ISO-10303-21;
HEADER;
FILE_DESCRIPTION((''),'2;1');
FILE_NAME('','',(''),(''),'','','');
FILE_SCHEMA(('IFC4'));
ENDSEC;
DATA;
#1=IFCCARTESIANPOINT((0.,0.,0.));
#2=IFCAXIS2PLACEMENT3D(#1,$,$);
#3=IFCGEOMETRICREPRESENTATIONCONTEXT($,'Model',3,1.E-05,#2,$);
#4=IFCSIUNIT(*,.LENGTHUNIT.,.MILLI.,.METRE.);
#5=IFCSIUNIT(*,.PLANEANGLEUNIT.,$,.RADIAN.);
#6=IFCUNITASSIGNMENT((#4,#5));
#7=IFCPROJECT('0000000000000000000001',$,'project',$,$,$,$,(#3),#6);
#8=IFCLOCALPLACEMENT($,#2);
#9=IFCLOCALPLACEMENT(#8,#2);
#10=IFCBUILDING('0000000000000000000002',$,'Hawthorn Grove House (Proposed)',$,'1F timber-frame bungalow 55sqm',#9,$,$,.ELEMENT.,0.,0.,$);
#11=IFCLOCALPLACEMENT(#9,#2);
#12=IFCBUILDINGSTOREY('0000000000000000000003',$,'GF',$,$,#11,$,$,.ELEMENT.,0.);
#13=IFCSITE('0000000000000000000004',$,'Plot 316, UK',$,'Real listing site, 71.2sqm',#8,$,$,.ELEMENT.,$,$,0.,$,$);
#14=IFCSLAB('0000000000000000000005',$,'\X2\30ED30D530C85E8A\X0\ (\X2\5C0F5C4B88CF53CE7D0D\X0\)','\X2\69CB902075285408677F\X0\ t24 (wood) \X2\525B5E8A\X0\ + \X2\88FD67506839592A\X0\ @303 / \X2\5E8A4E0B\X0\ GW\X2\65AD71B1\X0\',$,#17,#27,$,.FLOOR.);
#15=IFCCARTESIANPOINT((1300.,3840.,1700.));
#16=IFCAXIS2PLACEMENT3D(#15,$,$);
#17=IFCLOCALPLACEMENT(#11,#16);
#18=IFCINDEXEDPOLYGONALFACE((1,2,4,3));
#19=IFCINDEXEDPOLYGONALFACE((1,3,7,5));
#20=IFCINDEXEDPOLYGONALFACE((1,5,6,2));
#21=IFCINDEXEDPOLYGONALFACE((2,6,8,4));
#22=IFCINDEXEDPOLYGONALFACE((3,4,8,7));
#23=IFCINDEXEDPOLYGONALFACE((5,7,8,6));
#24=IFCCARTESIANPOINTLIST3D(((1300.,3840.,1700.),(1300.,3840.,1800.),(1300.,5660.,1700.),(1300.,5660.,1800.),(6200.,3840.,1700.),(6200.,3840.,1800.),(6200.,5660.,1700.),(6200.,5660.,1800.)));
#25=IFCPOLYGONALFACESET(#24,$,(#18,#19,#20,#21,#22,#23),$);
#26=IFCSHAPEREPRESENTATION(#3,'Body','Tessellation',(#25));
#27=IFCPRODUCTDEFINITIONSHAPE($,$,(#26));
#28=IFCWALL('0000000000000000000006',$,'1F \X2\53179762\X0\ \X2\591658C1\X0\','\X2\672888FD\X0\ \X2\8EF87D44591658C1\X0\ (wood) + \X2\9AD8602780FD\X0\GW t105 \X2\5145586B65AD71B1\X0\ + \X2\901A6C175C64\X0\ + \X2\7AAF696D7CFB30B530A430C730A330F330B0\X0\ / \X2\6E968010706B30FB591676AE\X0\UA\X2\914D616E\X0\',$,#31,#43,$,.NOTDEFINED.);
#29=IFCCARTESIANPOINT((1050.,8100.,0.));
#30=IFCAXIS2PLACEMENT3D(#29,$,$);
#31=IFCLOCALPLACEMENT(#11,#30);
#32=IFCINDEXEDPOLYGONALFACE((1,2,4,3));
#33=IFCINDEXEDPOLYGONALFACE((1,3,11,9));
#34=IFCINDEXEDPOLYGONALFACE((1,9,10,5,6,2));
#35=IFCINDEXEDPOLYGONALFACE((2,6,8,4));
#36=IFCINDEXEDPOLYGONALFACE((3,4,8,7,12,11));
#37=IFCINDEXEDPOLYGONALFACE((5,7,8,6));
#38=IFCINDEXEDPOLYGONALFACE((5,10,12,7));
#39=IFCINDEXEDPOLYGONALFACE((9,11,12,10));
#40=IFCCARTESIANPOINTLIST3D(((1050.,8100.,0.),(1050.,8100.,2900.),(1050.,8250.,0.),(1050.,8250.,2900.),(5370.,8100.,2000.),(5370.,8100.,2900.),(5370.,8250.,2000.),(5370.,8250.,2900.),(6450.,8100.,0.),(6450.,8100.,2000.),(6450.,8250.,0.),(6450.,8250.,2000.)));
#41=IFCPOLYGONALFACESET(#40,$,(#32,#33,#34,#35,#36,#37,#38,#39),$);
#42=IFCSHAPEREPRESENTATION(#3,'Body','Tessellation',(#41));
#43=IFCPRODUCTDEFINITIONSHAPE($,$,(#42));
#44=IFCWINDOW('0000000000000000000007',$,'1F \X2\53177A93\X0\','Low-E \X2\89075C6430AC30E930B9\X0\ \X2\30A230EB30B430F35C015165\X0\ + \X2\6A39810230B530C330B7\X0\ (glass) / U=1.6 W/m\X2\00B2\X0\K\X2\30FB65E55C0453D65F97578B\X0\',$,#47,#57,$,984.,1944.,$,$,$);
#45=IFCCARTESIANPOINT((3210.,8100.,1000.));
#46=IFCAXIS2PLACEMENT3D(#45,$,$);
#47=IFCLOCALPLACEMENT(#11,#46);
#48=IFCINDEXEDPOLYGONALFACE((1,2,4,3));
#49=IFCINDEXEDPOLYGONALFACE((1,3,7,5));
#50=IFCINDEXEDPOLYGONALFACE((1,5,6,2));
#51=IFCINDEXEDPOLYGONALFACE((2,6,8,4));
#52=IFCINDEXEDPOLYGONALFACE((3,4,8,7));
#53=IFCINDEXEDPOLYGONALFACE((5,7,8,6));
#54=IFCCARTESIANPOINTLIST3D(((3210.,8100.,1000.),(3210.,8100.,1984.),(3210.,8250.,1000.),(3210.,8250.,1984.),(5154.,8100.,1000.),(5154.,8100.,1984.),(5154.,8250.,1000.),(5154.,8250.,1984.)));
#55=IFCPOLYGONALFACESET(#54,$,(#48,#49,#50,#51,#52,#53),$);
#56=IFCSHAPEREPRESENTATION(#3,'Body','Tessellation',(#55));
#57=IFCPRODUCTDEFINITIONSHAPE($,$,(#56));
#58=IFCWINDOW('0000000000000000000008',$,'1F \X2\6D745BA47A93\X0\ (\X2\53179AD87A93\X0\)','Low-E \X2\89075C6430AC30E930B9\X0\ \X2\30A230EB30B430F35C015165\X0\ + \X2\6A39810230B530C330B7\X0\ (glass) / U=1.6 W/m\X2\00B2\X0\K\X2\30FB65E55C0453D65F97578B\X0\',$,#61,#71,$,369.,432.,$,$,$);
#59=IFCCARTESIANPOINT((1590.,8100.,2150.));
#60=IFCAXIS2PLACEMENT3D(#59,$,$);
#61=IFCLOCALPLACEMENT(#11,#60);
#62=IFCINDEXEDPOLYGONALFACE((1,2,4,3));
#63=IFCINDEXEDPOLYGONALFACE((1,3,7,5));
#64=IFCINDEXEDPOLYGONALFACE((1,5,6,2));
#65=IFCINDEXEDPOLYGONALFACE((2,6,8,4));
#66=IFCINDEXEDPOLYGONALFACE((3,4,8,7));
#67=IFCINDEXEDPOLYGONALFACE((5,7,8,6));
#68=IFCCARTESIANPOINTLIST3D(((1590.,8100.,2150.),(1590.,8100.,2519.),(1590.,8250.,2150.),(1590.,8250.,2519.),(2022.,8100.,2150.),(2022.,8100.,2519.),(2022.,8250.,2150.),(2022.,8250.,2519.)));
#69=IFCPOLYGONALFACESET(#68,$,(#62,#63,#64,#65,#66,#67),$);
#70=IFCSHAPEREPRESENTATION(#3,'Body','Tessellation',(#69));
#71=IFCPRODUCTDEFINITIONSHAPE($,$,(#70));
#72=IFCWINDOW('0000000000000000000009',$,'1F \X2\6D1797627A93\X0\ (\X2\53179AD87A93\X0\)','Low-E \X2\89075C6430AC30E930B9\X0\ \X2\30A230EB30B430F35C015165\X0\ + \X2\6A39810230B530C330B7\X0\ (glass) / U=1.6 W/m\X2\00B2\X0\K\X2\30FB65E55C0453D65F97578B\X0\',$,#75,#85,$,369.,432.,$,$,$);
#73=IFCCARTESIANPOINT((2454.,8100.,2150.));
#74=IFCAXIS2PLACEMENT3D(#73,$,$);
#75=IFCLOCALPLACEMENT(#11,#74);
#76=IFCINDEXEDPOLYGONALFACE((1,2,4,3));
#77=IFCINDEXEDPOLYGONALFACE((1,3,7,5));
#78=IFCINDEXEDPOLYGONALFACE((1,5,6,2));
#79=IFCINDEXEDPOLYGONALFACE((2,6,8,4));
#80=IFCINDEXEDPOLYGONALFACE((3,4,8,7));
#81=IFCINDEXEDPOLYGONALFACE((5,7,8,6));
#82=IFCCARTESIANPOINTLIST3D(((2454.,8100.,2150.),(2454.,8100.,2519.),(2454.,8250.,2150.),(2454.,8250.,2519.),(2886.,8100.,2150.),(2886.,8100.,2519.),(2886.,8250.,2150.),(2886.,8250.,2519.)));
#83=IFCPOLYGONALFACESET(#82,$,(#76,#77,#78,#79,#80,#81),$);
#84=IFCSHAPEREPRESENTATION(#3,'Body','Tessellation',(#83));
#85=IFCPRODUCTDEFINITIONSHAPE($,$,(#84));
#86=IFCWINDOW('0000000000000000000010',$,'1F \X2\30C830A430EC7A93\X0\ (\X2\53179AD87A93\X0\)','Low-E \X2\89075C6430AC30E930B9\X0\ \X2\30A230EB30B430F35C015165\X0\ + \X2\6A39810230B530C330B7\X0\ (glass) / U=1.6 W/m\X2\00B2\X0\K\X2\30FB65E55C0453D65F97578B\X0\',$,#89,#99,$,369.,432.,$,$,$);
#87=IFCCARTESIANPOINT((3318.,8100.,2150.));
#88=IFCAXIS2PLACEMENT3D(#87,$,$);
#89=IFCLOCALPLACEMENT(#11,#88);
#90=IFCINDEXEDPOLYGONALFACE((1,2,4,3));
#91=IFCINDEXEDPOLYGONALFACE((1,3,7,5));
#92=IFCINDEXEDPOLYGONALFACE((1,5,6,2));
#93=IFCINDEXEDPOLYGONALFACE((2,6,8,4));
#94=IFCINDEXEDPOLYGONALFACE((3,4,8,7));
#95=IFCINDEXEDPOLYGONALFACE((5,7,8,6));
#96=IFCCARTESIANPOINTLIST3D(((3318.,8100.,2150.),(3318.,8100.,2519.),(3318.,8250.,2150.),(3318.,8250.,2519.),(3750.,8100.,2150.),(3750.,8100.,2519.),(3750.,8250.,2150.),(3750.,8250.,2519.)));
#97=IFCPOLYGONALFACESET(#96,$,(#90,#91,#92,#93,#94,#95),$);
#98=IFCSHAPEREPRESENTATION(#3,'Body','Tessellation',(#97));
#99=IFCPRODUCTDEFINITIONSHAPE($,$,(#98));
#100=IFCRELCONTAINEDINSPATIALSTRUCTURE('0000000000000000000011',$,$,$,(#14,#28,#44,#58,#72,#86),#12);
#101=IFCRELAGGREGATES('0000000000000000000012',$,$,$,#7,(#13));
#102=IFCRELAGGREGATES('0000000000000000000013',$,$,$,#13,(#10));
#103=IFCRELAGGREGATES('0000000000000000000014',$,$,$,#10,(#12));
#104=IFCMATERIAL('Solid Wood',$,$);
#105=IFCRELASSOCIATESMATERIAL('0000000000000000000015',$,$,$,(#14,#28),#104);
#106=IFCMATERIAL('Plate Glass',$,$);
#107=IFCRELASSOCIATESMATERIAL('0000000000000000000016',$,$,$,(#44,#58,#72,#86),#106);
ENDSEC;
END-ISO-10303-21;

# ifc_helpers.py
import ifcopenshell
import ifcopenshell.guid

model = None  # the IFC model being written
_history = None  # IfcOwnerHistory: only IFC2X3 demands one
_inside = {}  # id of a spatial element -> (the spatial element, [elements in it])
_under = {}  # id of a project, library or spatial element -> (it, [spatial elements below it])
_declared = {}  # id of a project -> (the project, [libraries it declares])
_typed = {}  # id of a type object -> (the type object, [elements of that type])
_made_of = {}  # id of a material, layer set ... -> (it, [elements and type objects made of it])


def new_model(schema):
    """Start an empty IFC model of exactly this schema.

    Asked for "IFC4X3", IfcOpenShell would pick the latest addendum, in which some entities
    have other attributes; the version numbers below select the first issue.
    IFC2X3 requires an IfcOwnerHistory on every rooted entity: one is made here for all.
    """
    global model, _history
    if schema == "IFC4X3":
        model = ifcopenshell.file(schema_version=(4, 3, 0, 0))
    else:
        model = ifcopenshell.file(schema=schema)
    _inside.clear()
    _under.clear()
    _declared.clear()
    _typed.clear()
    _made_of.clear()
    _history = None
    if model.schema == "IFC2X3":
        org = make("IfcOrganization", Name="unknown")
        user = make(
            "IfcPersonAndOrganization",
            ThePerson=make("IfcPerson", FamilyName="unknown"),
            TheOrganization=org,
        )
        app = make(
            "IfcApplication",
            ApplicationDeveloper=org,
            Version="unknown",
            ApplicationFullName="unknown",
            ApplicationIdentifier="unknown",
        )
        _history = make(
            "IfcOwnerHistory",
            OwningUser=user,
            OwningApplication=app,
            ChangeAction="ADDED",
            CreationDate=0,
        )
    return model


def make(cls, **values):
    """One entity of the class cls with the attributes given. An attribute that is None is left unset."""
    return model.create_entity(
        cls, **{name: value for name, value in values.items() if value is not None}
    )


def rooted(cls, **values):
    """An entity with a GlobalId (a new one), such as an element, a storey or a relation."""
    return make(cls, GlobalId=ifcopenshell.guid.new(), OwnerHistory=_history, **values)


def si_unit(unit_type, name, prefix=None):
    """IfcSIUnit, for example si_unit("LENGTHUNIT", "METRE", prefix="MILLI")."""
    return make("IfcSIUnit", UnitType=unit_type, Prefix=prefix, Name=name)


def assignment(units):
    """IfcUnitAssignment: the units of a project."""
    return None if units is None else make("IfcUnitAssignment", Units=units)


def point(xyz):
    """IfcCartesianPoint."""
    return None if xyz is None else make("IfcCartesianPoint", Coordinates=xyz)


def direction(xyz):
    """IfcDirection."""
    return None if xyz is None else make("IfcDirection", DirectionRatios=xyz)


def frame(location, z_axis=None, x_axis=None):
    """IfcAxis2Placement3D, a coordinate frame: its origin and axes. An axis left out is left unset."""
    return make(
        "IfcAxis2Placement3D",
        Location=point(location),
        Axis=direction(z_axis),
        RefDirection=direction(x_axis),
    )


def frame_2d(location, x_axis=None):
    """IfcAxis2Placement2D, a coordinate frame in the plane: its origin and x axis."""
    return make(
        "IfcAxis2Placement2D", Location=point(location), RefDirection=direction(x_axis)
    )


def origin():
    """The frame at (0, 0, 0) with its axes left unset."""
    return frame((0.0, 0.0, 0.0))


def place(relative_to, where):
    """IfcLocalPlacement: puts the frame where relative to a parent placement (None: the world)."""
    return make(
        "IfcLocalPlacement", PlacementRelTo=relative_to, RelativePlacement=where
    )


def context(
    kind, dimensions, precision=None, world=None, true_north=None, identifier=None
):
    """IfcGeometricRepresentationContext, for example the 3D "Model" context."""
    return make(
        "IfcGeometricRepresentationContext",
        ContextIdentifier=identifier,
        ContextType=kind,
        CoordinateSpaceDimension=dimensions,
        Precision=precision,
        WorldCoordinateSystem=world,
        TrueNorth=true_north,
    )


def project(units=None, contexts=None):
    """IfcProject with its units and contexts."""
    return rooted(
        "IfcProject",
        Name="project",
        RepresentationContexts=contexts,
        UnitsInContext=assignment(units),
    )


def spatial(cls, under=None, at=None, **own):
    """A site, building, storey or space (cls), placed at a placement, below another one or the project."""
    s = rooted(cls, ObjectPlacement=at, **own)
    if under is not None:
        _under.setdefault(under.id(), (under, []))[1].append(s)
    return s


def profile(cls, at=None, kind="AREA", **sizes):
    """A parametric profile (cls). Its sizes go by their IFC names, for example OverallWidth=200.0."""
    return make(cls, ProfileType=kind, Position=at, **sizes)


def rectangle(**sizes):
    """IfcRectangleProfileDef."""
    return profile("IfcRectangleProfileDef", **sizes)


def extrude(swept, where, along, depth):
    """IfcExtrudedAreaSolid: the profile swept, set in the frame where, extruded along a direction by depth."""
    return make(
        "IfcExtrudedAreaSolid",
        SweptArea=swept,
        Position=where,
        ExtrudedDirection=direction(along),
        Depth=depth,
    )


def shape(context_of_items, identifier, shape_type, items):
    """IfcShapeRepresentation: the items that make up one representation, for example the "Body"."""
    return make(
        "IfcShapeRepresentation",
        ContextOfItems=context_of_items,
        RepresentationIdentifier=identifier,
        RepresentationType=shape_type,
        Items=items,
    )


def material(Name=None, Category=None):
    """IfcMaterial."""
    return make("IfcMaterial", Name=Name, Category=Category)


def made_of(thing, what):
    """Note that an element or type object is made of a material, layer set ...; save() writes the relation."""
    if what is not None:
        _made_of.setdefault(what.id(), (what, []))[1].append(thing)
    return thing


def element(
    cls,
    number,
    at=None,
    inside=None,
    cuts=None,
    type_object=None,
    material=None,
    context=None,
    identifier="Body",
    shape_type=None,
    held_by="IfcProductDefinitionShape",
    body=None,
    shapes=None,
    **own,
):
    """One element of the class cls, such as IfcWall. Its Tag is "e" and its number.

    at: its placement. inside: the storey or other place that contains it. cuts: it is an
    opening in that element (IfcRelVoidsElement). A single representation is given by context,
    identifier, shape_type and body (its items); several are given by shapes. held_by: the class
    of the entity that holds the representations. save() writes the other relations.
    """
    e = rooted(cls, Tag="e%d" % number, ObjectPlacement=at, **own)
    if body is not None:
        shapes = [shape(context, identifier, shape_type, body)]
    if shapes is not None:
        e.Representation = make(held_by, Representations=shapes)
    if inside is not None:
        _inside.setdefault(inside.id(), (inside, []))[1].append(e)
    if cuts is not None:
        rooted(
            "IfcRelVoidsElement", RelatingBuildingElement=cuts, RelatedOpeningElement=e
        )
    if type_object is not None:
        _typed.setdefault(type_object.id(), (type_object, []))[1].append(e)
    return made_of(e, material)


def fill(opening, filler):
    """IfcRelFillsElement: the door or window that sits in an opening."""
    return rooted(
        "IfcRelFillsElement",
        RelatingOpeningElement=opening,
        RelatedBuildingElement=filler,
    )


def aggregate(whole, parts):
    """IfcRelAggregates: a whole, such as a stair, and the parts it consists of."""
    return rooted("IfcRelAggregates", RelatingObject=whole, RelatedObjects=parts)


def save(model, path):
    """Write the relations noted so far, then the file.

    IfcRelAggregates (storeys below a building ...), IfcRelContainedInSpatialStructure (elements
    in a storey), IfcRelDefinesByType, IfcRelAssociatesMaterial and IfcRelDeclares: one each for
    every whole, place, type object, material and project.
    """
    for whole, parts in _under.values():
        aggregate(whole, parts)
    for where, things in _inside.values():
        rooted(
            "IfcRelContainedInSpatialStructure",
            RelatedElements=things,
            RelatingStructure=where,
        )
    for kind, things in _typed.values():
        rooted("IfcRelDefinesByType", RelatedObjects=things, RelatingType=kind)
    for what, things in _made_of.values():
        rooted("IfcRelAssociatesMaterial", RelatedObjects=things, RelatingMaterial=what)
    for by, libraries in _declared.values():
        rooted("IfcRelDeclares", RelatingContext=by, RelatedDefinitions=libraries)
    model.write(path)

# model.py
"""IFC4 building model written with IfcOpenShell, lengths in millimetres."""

from ifc_helpers import new_model, si_unit, frame, frame_2d, origin, place, context, project, spatial, rectangle, extrude, material, element, fill, save


model = new_model("IFC4")

# Units and contexts
model_context = context("Model", 3, precision=1e-05, world=origin())
ifc_project = project(units=[si_unit("LENGTHUNIT", "METRE", prefix="MILLI"), si_unit("PLANEANGLEUNIT", "RADIAN")], contexts=[model_context])

# Site, building, storey
site_placement = place(None, origin())
site = spatial("IfcSite", under=ifc_project, at=site_placement, Name="Plot 316, UK", ObjectType="Real listing site, 71.2sqm", CompositionType="ELEMENT", RefElevation=0.0)
building_placement = place(site_placement, origin())
building = spatial("IfcBuilding", under=site, at=building_placement, Name="Hawthorn Grove House (Proposed)", ObjectType="1F timber-frame bungalow 55sqm", CompositionType="ELEMENT", ElevationOfRefHeight=0.0, ElevationOfTerrain=0.0)
storey_placement = place(building_placement, origin())
storey = spatial("IfcBuildingStorey", under=building, at=storey_placement, Name="GF", CompositionType="ELEMENT", Elevation=0.0)

# Slab
ifc_material_1 = material(Name="Solid Wood")
slab_placement = place(storey_placement, frame((1300.0, 3840.0, 1700.0)))
element("IfcSlab", 1, at=slab_placement, inside=storey, material=ifc_material_1, Name="ロフト床 (小屋裏収納)", Description="構造用合板 t24 (wood) 剛床 + 製材根太 @303 / 床下 GW断熱", PredefinedType="FLOOR", context=model_context, shape_type="SweptSolid", body=[
    extrude(rectangle(XDim=4900.0, YDim=1820.0, at=frame_2d((2450.0, 910.0))), frame((1300.0, 3840.0, 1700.0)), (0.0, 0.0, 1.0), 100.0),
])

# Wall, openings, windows
wall_1_placement = place(storey_placement, frame((1050.0, 8100.0, 0.0)))
wall_1 = element("IfcWall", 2, at=wall_1_placement, inside=storey, material=ifc_material_1, Name="1F 北面 外壁", Description="木製 軸組外壁 (wood) + 高性能GW t105 充填断熱 + 通気層 + 窯業系サイディング / 準耐火・外皮UA配慮", PredefinedType="NOTDEFINED", context=model_context, shape_type="SweptSolid", body=[
    extrude(rectangle(XDim=5400.0, YDim=150.0, at=frame_2d((2700.0, 75.0))), frame((1050.0, 8100.0, 0.0)), (0.0, 0.0, 1.0), 2900.0),
])
opening_1_placement = place(storey_placement, frame((3210.0, 8100.0, 1000.0)))
opening_1 = element("IfcOpeningElement", 3, at=opening_1_placement, cuts=wall_1, PredefinedType="NOTDEFINED", context=model_context, shape_type="SweptSolid", body=[
    extrude(rectangle(XDim=1944.0, YDim=150.0, at=frame_2d((972.0, 75.0))), frame((3210.0, 8100.0, 1000.0)), (0.0, 0.0, 1.0), 984.0),
])
opening_2_placement = place(storey_placement, frame((1590.0, 8100.0, 2150.0)))
opening_2 = element("IfcOpeningElement", 4, at=opening_2_placement, cuts=wall_1, PredefinedType="NOTDEFINED", context=model_context, shape_type="SweptSolid", body=[
    extrude(rectangle(XDim=432.0, YDim=150.0, at=frame_2d((216.0, 75.0))), frame((1590.0, 8100.0, 2150.0)), (0.0, 0.0, 1.0), 369.0),
])
opening_3_placement = place(storey_placement, frame((2454.0, 8100.0, 2150.0)))
opening_3 = element("IfcOpeningElement", 5, at=opening_3_placement, cuts=wall_1, PredefinedType="NOTDEFINED", context=model_context, shape_type="SweptSolid", body=[
    extrude(rectangle(XDim=432.0, YDim=150.0, at=frame_2d((216.0, 75.0))), frame((2454.0, 8100.0, 2150.0)), (0.0, 0.0, 1.0), 369.0),
])
opening_4_placement = place(storey_placement, frame((3318.0, 8100.0, 2150.0)))
opening_4 = element("IfcOpeningElement", 6, at=opening_4_placement, cuts=wall_1, PredefinedType="NOTDEFINED", context=model_context, shape_type="SweptSolid", body=[
    extrude(rectangle(XDim=432.0, YDim=150.0, at=frame_2d((216.0, 75.0))), frame((3318.0, 8100.0, 2150.0)), (0.0, 0.0, 1.0), 369.0),
])
ifc_material_2 = material(Name="Plate Glass")
window_1_placement = place(storey_placement, frame((3210.0, 8100.0, 1000.0)))
window_1 = element("IfcWindow", 7, at=window_1_placement, inside=storey, material=ifc_material_2, Name="1F 北窓", Description="Low-E 複層ガラス アルゴン封入 + 樹脂サッシ (glass) / U=1.6 W/m²K・日射取得型", OverallHeight=984.0, OverallWidth=1944.0, context=model_context, shape_type="SweptSolid", body=[
    extrude(rectangle(XDim=1944.0, YDim=150.0, at=frame_2d((972.0, 75.0))), frame((3210.0, 8100.0, 1000.0)), (0.0, 0.0, 1.0), 984.0),
])
fill(opening_1, window_1)
window_2_placement = place(storey_placement, frame((1590.0, 8100.0, 2150.0)))
window_2 = element("IfcWindow", 8, at=window_2_placement, inside=storey, material=ifc_material_2, Name="1F 浴室窓 (北高窓)", Description="Low-E 複層ガラス アルゴン封入 + 樹脂サッシ (glass) / U=1.6 W/m²K・日射取得型", OverallHeight=369.0, OverallWidth=432.0, context=model_context, shape_type="SweptSolid", body=[
    extrude(rectangle(XDim=432.0, YDim=150.0, at=frame_2d((216.0, 75.0))), frame((1590.0, 8100.0, 2150.0)), (0.0, 0.0, 1.0), 369.0),
])
fill(opening_2, window_2)
window_3_placement = place(storey_placement, frame((2454.0, 8100.0, 2150.0)))
window_3 = element("IfcWindow", 9, at=window_3_placement, inside=storey, material=ifc_material_2, Name="1F 洗面窓 (北高窓)", Description="Low-E 複層ガラス アルゴン封入 + 樹脂サッシ (glass) / U=1.6 W/m²K・日射取得型", OverallHeight=369.0, OverallWidth=432.0, context=model_context, shape_type="SweptSolid", body=[
    extrude(rectangle(XDim=432.0, YDim=150.0, at=frame_2d((216.0, 75.0))), frame((2454.0, 8100.0, 2150.0)), (0.0, 0.0, 1.0), 369.0),
])
fill(opening_3, window_3)
window_4_placement = place(storey_placement, frame((3318.0, 8100.0, 2150.0)))
window_4 = element("IfcWindow", 10, at=window_4_placement, inside=storey, material=ifc_material_2, Name="1F トイレ窓 (北高窓)", Description="Low-E 複層ガラス アルゴン封入 + 樹脂サッシ (glass) / U=1.6 W/m²K・日射取得型", OverallHeight=369.0, OverallWidth=432.0, context=model_context, shape_type="SweptSolid", body=[
    extrude(rectangle(XDim=432.0, YDim=150.0, at=frame_2d((216.0, 75.0))), frame((3318.0, 8100.0, 2150.0)), (0.0, 0.0, 1.0), 369.0),
])
fill(opening_4, window_4)

save(model, "model.ifc")
